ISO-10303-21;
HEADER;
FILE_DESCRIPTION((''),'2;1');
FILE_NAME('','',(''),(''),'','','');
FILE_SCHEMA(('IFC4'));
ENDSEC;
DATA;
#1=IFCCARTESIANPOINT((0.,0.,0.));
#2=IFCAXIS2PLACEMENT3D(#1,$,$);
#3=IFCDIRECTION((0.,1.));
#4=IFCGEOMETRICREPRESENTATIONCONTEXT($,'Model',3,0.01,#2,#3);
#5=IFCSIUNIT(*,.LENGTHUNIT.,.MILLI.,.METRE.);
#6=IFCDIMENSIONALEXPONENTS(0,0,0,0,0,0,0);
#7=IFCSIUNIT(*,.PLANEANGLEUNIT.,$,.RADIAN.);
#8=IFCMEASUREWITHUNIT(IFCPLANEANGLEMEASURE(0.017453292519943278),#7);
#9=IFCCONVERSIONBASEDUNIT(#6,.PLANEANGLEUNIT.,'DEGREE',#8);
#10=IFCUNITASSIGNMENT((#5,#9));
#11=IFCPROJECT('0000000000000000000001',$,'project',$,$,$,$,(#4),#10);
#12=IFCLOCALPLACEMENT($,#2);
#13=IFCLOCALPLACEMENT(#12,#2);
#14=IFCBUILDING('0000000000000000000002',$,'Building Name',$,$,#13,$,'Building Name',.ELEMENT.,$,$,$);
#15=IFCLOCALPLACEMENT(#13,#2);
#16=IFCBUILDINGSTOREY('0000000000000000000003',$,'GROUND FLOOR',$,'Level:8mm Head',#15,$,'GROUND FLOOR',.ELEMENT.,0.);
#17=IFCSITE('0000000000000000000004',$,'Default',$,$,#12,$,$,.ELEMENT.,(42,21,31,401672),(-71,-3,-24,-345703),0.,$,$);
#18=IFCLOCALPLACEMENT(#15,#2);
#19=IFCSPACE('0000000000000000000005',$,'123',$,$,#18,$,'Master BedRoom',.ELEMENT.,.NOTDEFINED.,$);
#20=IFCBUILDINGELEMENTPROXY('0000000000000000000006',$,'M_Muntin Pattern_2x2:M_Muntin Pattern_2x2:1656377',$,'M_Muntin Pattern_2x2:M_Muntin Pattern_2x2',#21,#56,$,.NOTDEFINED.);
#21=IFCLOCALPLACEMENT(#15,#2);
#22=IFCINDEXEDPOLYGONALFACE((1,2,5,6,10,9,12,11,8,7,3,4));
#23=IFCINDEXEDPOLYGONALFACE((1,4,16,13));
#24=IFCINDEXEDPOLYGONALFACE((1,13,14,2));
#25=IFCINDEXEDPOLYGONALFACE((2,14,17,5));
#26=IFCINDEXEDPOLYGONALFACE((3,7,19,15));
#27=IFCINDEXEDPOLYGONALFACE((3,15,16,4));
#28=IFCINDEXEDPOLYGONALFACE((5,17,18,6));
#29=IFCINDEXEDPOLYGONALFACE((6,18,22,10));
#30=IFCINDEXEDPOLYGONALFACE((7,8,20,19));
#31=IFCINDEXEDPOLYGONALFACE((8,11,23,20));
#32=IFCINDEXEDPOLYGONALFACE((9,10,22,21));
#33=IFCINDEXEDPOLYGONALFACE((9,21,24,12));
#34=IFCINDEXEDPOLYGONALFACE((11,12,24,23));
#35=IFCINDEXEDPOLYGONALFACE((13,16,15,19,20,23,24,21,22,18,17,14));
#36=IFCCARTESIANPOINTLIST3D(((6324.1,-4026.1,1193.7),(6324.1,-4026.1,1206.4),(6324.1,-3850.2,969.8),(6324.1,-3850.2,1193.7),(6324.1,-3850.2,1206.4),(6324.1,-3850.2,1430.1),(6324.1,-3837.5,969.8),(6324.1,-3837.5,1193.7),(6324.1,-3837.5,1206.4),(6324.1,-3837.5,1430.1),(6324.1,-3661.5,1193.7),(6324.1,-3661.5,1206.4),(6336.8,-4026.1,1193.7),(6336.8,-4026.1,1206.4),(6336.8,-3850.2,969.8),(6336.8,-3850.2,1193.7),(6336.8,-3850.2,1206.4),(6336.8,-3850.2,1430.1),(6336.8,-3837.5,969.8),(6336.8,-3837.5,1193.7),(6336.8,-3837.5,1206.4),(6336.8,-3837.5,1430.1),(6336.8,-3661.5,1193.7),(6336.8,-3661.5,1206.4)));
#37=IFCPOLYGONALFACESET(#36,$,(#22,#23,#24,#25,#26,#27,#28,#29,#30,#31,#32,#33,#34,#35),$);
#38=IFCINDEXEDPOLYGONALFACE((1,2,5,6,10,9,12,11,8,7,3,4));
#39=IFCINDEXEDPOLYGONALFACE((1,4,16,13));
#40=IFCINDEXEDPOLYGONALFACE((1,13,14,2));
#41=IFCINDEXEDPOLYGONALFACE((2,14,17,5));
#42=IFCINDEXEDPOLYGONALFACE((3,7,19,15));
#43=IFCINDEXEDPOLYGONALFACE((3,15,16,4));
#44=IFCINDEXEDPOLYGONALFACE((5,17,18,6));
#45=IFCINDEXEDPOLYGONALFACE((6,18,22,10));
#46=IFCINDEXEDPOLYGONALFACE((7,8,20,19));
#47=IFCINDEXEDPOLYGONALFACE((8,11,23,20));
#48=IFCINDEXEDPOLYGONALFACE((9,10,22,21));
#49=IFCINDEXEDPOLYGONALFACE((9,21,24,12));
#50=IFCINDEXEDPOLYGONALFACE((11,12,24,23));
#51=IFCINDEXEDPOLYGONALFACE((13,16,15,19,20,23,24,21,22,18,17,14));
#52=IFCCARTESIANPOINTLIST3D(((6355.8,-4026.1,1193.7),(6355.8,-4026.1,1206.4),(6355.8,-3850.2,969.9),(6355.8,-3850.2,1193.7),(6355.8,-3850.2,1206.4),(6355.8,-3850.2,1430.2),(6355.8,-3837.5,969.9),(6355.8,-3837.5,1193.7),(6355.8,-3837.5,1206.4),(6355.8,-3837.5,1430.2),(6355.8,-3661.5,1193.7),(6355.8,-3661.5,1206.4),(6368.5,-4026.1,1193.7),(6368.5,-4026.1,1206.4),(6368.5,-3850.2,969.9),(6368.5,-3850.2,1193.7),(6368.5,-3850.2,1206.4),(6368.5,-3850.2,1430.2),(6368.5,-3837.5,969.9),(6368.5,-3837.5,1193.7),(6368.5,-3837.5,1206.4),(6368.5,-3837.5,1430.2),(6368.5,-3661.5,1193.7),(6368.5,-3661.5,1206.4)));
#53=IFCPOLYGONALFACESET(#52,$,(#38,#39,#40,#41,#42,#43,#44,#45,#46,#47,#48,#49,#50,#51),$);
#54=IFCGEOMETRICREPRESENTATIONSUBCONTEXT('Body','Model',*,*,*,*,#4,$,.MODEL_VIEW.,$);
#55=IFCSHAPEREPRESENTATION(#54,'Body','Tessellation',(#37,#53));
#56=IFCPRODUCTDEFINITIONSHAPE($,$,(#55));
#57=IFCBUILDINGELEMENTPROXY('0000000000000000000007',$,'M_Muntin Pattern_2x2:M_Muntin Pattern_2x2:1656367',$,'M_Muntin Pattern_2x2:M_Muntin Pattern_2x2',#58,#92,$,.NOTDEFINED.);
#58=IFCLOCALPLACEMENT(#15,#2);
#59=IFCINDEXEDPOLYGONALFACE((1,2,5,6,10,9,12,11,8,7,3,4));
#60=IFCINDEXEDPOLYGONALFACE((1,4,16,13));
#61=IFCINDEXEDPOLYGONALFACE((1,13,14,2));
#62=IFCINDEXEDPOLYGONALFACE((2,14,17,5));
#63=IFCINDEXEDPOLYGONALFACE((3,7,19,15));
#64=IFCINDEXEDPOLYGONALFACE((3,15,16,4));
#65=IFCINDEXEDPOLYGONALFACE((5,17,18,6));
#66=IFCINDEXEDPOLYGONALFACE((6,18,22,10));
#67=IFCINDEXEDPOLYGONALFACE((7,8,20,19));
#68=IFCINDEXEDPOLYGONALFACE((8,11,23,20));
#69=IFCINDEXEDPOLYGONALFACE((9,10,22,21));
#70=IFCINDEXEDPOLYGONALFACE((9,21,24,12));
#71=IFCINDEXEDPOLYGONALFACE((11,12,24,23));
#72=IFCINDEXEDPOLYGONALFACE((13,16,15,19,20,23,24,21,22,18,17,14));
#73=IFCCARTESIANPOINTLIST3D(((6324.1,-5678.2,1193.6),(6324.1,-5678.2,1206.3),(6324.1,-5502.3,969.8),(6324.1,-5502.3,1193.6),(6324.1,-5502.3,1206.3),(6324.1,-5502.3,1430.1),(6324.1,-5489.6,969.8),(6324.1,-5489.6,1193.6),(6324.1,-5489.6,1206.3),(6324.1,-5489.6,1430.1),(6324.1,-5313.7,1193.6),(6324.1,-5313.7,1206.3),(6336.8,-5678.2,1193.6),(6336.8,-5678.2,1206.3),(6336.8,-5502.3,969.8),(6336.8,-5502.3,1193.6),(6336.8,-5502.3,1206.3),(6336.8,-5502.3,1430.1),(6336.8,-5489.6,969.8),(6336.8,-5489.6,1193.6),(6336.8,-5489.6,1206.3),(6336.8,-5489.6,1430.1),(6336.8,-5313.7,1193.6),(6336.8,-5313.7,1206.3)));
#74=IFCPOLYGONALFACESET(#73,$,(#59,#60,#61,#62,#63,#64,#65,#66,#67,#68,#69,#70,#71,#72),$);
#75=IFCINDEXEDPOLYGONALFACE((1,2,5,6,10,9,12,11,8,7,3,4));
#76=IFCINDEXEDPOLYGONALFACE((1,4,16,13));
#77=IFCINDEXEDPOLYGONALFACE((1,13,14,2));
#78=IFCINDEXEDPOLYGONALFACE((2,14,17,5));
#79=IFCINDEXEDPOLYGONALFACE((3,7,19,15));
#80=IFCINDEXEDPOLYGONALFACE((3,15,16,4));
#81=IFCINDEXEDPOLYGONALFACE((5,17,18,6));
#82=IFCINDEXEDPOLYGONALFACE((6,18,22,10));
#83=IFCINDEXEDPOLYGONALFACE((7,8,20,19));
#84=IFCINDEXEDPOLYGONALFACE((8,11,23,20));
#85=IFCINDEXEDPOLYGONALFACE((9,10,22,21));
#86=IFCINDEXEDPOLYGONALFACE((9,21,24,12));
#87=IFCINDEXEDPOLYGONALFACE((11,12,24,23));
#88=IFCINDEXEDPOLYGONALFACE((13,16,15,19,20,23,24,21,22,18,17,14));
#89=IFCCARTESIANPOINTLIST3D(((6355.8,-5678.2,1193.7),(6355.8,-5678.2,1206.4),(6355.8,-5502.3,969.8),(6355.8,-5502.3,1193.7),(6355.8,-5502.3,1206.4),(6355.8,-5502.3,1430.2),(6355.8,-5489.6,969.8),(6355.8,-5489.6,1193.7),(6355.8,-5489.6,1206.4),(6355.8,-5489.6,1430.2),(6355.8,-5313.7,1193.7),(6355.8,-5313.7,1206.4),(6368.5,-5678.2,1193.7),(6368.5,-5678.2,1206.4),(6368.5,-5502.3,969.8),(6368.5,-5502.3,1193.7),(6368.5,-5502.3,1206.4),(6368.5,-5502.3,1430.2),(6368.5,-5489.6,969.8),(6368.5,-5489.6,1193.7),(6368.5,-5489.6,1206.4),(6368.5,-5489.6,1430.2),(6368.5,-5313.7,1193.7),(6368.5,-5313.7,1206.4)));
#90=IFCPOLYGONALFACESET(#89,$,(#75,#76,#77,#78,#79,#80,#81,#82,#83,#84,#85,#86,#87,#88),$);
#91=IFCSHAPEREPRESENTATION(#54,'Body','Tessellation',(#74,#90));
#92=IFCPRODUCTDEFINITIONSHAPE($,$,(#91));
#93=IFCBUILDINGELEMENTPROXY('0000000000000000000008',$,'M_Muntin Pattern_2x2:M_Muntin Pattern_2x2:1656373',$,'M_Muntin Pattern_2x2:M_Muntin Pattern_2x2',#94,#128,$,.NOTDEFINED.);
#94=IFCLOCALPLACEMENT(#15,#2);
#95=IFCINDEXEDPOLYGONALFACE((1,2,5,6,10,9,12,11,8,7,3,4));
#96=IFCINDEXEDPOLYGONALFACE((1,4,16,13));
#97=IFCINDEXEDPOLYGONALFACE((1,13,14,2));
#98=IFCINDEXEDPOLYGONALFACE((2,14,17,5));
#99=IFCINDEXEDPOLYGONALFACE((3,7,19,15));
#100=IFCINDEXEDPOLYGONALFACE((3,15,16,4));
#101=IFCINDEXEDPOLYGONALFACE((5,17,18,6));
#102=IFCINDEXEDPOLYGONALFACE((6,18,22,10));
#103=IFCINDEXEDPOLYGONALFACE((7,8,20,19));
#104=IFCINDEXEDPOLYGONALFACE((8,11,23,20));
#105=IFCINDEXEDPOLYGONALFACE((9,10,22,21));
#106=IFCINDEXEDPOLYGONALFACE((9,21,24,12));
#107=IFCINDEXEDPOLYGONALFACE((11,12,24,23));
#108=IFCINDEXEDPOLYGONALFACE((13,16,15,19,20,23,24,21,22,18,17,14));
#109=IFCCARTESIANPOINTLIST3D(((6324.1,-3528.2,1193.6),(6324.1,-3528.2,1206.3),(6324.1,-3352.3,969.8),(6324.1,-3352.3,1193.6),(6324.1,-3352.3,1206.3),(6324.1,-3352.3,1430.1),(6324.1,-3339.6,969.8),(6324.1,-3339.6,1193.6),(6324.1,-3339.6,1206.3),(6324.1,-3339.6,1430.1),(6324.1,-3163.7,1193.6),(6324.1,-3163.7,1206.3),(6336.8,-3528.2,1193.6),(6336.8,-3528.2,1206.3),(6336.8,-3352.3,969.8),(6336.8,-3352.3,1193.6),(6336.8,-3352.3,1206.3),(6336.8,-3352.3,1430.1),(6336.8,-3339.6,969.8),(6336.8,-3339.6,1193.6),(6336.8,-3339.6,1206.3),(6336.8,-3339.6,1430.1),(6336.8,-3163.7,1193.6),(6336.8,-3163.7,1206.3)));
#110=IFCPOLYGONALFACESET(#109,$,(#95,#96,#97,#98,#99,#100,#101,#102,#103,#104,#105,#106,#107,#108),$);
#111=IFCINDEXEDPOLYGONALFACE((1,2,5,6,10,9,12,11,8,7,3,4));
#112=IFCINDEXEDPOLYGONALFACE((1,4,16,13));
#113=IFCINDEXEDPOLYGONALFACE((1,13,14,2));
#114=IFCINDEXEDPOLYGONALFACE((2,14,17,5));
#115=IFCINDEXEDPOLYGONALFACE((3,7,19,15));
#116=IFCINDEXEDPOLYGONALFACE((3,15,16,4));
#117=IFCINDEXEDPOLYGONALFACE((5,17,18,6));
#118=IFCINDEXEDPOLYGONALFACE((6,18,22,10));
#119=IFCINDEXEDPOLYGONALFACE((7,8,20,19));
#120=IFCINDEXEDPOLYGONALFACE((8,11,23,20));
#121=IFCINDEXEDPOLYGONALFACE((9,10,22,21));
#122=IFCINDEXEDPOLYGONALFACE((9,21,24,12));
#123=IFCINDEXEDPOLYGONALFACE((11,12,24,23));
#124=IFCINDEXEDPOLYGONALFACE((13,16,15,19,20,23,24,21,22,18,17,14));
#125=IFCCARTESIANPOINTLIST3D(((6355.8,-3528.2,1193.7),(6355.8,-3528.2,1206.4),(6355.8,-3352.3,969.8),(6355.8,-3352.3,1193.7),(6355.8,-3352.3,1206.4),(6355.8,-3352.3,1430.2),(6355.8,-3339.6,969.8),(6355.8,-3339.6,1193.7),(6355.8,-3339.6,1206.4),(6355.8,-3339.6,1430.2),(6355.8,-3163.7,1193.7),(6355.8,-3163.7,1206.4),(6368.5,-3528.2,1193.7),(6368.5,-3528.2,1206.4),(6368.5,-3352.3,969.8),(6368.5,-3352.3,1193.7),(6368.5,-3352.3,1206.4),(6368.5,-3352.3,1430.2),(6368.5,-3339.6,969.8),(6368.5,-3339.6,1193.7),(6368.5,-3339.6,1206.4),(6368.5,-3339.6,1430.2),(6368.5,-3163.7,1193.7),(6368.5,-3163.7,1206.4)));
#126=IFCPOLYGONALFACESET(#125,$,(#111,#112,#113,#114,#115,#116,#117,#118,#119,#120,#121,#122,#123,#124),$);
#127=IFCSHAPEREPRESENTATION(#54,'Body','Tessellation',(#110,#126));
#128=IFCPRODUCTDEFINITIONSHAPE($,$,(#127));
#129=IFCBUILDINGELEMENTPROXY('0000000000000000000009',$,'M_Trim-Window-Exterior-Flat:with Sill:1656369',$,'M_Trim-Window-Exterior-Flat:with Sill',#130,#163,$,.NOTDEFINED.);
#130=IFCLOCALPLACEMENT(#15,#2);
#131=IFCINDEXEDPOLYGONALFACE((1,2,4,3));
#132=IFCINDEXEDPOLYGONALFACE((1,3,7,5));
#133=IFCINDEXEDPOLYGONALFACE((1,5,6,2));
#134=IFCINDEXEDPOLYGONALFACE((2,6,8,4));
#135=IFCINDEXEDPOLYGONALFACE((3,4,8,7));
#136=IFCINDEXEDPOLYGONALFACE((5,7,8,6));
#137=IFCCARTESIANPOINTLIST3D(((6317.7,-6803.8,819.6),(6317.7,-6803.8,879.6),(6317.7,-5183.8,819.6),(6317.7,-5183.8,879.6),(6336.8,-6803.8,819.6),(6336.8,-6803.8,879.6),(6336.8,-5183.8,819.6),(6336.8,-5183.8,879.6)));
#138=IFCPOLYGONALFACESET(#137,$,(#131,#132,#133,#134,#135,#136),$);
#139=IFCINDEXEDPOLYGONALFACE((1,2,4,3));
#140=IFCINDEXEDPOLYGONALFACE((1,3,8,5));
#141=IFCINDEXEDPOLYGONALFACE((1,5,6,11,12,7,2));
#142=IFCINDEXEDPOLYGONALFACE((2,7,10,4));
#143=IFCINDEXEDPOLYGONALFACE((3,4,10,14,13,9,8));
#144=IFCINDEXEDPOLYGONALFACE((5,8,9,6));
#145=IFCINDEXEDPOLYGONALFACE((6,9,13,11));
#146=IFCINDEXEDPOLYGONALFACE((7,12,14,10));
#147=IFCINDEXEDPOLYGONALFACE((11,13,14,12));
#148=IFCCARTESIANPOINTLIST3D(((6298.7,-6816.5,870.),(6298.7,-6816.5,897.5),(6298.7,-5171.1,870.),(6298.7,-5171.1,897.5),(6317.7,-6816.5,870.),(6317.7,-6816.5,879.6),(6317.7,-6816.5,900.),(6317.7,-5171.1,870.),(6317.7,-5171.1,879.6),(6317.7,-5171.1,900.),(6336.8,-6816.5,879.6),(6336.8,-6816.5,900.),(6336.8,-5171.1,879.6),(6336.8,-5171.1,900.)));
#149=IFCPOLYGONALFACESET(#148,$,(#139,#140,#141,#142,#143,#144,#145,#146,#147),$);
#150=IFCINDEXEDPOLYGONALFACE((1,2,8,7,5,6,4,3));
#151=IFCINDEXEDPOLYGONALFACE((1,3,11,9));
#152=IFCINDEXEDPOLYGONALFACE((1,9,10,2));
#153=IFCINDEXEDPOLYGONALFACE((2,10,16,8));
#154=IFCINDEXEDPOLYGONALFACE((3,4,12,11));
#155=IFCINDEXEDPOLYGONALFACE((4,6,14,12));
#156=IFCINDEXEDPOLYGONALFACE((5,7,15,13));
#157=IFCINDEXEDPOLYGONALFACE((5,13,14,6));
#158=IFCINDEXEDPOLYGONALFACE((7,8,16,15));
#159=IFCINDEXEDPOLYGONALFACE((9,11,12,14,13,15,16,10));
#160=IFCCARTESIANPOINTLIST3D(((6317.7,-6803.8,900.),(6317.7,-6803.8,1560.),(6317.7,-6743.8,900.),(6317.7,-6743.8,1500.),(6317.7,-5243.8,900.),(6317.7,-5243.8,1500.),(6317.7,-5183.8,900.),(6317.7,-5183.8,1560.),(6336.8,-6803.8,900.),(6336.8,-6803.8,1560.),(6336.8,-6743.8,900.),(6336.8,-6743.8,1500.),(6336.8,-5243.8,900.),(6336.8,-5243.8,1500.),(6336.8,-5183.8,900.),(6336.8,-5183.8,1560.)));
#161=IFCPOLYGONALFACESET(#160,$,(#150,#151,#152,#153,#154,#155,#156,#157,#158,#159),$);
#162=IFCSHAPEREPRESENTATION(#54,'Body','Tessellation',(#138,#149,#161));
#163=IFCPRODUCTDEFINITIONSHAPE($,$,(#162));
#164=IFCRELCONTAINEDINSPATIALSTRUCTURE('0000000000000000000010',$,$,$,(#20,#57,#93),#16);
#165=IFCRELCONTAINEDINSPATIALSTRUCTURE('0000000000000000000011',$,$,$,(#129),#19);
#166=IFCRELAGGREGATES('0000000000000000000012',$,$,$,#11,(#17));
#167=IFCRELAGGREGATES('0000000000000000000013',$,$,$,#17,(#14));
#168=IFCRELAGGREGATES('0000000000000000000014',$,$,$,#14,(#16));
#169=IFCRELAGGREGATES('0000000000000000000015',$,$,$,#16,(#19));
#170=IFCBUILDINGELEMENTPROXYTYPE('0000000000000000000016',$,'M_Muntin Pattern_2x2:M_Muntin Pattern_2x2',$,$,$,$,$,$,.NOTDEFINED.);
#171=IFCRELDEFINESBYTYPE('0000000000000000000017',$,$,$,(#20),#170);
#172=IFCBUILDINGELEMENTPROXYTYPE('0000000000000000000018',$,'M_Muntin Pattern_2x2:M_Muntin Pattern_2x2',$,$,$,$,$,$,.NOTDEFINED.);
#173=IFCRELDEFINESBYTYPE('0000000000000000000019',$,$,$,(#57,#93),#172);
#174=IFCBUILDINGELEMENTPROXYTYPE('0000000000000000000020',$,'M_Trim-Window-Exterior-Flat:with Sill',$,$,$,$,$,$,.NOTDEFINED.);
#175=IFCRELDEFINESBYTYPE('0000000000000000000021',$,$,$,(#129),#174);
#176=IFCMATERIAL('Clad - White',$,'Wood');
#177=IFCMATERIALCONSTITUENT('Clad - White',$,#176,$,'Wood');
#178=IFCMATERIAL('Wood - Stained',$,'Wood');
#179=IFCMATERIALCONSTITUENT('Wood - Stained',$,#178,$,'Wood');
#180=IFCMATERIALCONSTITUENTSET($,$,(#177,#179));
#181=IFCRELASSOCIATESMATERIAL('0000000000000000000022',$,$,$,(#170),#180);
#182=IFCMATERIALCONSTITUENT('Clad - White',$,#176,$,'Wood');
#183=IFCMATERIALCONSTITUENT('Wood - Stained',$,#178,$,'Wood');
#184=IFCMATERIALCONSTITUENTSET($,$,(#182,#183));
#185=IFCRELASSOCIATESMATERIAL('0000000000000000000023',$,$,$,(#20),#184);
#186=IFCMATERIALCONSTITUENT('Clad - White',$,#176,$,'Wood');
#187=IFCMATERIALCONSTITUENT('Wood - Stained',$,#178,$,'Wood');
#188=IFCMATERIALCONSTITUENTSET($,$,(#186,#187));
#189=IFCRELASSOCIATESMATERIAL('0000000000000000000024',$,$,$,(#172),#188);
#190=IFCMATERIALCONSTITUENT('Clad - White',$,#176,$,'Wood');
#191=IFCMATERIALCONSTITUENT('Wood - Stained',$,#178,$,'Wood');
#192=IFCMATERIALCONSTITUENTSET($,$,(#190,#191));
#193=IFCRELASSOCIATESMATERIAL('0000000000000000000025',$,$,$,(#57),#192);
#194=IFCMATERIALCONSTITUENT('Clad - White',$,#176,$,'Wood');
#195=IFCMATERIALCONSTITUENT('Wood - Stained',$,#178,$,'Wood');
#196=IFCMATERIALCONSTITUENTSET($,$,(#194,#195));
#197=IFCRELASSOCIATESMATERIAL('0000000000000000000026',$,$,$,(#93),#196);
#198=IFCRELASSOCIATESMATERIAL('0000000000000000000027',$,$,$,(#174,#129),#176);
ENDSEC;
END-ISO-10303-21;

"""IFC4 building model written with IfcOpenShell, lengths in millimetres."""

from ifc_helpers import new_model, entity, si_unit, converted_unit, direction, frame, origin, place, context, subcontext, project, spatial, indexed_curve, outline, extrude, source, transform, mapped, material, constituent, constituent_set, type_object, type_shapes, element, save


model = new_model("IFC4")

# Units and contexts
model_context = context("Model", 3, precision=0.01, world=origin(), true_north=direction((0.0, 1.0)))
body_context = subcontext(model_context, "Body", "Model", "MODEL_VIEW")
ifc_project = project(units=[si_unit("LENGTHUNIT", "METRE", prefix="MILLI"), converted_unit("PLANEANGLEUNIT", "DEGREE", entity("IfcPlaneAngleMeasure", 0.017453292519943278), si_unit("PLANEANGLEUNIT", "RADIAN"), dimensions=[0, 0, 0, 0, 0, 0, 0])], contexts=[model_context])

# Site, building, storey
site_placement = place(None, origin())
site = spatial("IfcSite", under=ifc_project, at=site_placement, Name="Default", CompositionType="ELEMENT", RefLatitude=(42, 21, 31, 401672), RefLongitude=(-71, -3, -24, -345703), RefElevation=0.0)
building_placement = place(site_placement, origin())
building = spatial("IfcBuilding", under=site, at=building_placement, Name="Building Name", LongName="Building Name", CompositionType="ELEMENT")
storey_placement = place(building_placement, origin())
storey = spatial("IfcBuildingStorey", under=building, at=storey_placement, Name="GROUND FLOOR", ObjectType="Level:8mm Head", LongName="GROUND FLOOR", CompositionType="ELEMENT", Elevation=0.0)

# Shared definitions
ifc_material_1 = material(Name="Wood - Stained", Category="Wood")

# Shared definitions
space_1_placement = place(storey_placement, origin())
space_1 = spatial("IfcSpace", under=storey, at=space_1_placement, Name="123", LongName="Master BedRoom", CompositionType="ELEMENT", PredefinedType="NOTDEFINED")

# Building element proxies
ifc_material_2 = material(Name="Clad - White", Category="Wood")
ifc_constituent_1 = constituent(ifc_material_2, Name="Clad - White", Category="Wood")
ifc_constituent_2 = constituent(ifc_material_1, Name="Wood - Stained", Category="Wood")
ifc_constituent_set_1 = constituent_set(constituents=[ifc_constituent_1, ifc_constituent_2])
building_element_proxy_type_1 = type_object("IfcBuildingElementProxyType", Name="M_Muntin Pattern_2x2:M_Muntin Pattern_2x2", PredefinedType="NOTDEFINED", material=ifc_constituent_set_1)
shared_shape_1 = source(origin(), body_context, "Body", "SweptSolid", [
    extrude(outline(indexed_curve([(6.4, -6.4), (230.1, -6.4), (230.1, 6.3), (6.4, 6.3), (6.4, 182.3), (-6.3, 182.3), (-6.3, 6.3), (-230.2, 6.3), (-230.2, -6.4), (-6.3, -6.4), (-6.3, -182.3), (6.4, -182.3), (6.4, -6.4)], self_intersect=False)), frame((0.0, 9.5, 230.1), z_axis=(0.0, 1.0, 0.0), x_axis=(0.0, 0.0, 1.0)), (0.0, 0.0, 1.0), 12.7),
    extrude(outline(indexed_curve([(6.4, -6.4), (230.2, -6.4), (230.2, 6.3), (6.4, 6.3), (6.4, 182.3), (-6.3, 182.3), (-6.3, 6.3), (-230.2, 6.3), (-230.2, -6.4), (-6.3, -6.4), (-6.3, -182.3), (6.4, -182.3), (6.4, -6.4)], self_intersect=False)), frame((0.0, -22.2, 230.2), z_axis=(0.0, 1.0, 0.0), x_axis=(0.0, 0.0, 1.0)), (0.0, 0.0, 1.0), 12.7),
])
type_shapes(building_element_proxy_type_1, [shared_shape_1])
ifc_constituent_3 = constituent(ifc_material_2, Name="Clad - White", Category="Wood")
ifc_constituent_4 = constituent(ifc_material_1, Name="Wood - Stained", Category="Wood")
ifc_constituent_set_2 = constituent_set(constituents=[ifc_constituent_3, ifc_constituent_4])
proxy_1_placement = place(storey_placement, frame((6346.3, -3843.8, 969.9), z_axis=(0.0, 0.0, 1.0), x_axis=(0.0, 1.0, 0.0)))
element("IfcBuildingElementProxy", 1, at=proxy_1_placement, inside=storey, type_object=building_element_proxy_type_1, material=ifc_constituent_set_2, Name="M_Muntin Pattern_2x2:M_Muntin Pattern_2x2:1656377", ObjectType="M_Muntin Pattern_2x2:M_Muntin Pattern_2x2", PredefinedType="NOTDEFINED", context=body_context, shape_type="MappedRepresentation", body=[
    mapped(shared_shape_1, transform((0.0, 0.0, 0.0), scale=1.0)),
])
ifc_constituent_5 = constituent(ifc_material_2, Name="Clad - White", Category="Wood")
ifc_constituent_6 = constituent(ifc_material_1, Name="Wood - Stained", Category="Wood")
ifc_constituent_set_3 = constituent_set(constituents=[ifc_constituent_5, ifc_constituent_6])
ifc_constituent_7 = constituent(ifc_material_2, Name="Clad - White", Category="Wood")
ifc_constituent_8 = constituent(ifc_material_1, Name="Wood - Stained", Category="Wood")
ifc_constituent_set_4 = constituent_set(constituents=[ifc_constituent_7, ifc_constituent_8])
building_element_proxy_type_2 = type_object("IfcBuildingElementProxyType", Name="M_Muntin Pattern_2x2:M_Muntin Pattern_2x2", PredefinedType="NOTDEFINED", material=ifc_constituent_set_4)
shared_shape_2 = source(origin(), body_context, "Body", "SweptSolid", [
    extrude(outline(indexed_curve([(6.4, -6.4), (230.1, -6.4), (230.1, 6.3), (6.4, 6.3), (6.4, 182.3), (-6.3, 182.3), (-6.3, 6.3), (-230.2, 6.3), (-230.2, -6.4), (-6.3, -6.4), (-6.3, -182.3), (6.4, -182.3), (6.4, -6.4)], self_intersect=False)), frame((0.0, -22.2, 230.1), z_axis=(0.0, 1.0, 0.0), x_axis=(0.0, 0.0, 1.0)), (0.0, 0.0, 1.0), 12.7),
    extrude(outline(indexed_curve([(6.4, -6.4), (230.2, -6.4), (230.2, 6.3), (6.4, 6.3), (6.4, 182.3), (-6.3, 182.3), (-6.3, 6.3), (-230.2, 6.3), (-230.2, -6.4), (-6.3, -6.4), (-6.3, -182.3), (6.4, -182.3), (6.4, -6.4)], self_intersect=False)), frame((0.0, 9.5, 230.2), z_axis=(0.0, 1.0, 0.0), x_axis=(0.0, 0.0, 1.0)), (0.0, 0.0, 1.0), 12.7),
])
type_shapes(building_element_proxy_type_2, [shared_shape_2])
proxy_2_placement = place(storey_placement, frame((6346.3, -5495.9, 969.8), z_axis=(0.0, 0.0, 1.0), x_axis=(0.0, -1.0, 0.0)))
element("IfcBuildingElementProxy", 2, at=proxy_2_placement, inside=storey, type_object=building_element_proxy_type_2, material=ifc_constituent_set_3, Name="M_Muntin Pattern_2x2:M_Muntin Pattern_2x2:1656367", ObjectType="M_Muntin Pattern_2x2:M_Muntin Pattern_2x2", PredefinedType="NOTDEFINED", context=body_context, shape_type="MappedRepresentation", body=[
    mapped(shared_shape_2, transform((0.0, 0.0, 0.0), scale=1.0)),
])
ifc_constituent_9 = constituent(ifc_material_2, Name="Clad - White", Category="Wood")
ifc_constituent_10 = constituent(ifc_material_1, Name="Wood - Stained", Category="Wood")
ifc_constituent_set_5 = constituent_set(constituents=[ifc_constituent_9, ifc_constituent_10])
proxy_3_placement = place(storey_placement, frame((6346.3, -3345.9, 969.8), z_axis=(0.0, 0.0, 1.0), x_axis=(0.0, -1.0, 0.0)))
element("IfcBuildingElementProxy", 3, at=proxy_3_placement, inside=storey, type_object=building_element_proxy_type_2, material=ifc_constituent_set_5, Name="M_Muntin Pattern_2x2:M_Muntin Pattern_2x2:1656373", ObjectType="M_Muntin Pattern_2x2:M_Muntin Pattern_2x2", PredefinedType="NOTDEFINED", context=body_context, shape_type="MappedRepresentation", body=[
    mapped(shared_shape_2, transform((0.0, 0.0, 0.0), scale=1.0)),
])
building_element_proxy_type_3 = type_object("IfcBuildingElementProxyType", Name="M_Trim-Window-Exterior-Flat:with Sill", PredefinedType="NOTDEFINED", material=ifc_material_2)
shared_shape_3 = source(origin(), body_context, "Body", "SweptSolid", [
    extrude(outline(indexed_curve([(-30.0, -810.0), (30.0, -810.0), (30.0, 810.0), (-30.0, 810.0), (-30.0, -810.0)], self_intersect=False)), frame((0.0, 650.4, 0.0), z_axis=(0.0, 0.0, 1.0), x_axis=(0.0, 1.0, 0.0)), (0.0, 0.0, 1.0), 19.0),
    extrude(outline(indexed_curve([(-15.2, -19.0), (12.3, -19.0), (14.8, 0.0), (14.8, 19.0), (-5.7, 19.0), (-5.7, 0.0), (-15.2, 0.0), (-15.2, -19.0)], self_intersect=False)), frame((-822.7, 614.8, 19.0), z_axis=(1.0, 0.0, 0.0), x_axis=(0.0, -1.0, 0.0)), (0.0, 0.0, 1.0), 1645.4),
    extrude(outline(indexed_curve([(-810.0, -345.0), (810.0, -345.0), (810.0, 315.0), (750.0, 315.0), (750.0, -285.0), (-750.0, -285.0), (-750.0, 315.0), (-810.0, 315.0), (-810.0, -345.0)], self_intersect=False)), frame((0.0, 285.0, 0.0)), (0.0, 0.0, 1.0), 19.0),
])
type_shapes(building_element_proxy_type_3, [shared_shape_3])
for number, where, z_axis, x_axis, name in (
    (4, (6336.8, -5993.8, 1500.0), (-1.0, 0.0, 0.0), (0.0, 1.0, 0.0), "M_Trim-Window-Exterior-Flat:with Sill:1656369"),
):
    element("IfcBuildingElementProxy", number, at=place(space_1_placement, frame(where, z_axis=z_axis, x_axis=x_axis)), inside=space_1, type_object=building_element_proxy_type_3, material=ifc_material_2, Name=name, ObjectType="M_Trim-Window-Exterior-Flat:with Sill", PredefinedType="NOTDEFINED", context=body_context, shape_type="MappedRepresentation", body=[
        mapped(shared_shape_3, transform((0.0, 0.0, 0.0), scale=1.0)),
    ])

save(model, "model.ifc")
